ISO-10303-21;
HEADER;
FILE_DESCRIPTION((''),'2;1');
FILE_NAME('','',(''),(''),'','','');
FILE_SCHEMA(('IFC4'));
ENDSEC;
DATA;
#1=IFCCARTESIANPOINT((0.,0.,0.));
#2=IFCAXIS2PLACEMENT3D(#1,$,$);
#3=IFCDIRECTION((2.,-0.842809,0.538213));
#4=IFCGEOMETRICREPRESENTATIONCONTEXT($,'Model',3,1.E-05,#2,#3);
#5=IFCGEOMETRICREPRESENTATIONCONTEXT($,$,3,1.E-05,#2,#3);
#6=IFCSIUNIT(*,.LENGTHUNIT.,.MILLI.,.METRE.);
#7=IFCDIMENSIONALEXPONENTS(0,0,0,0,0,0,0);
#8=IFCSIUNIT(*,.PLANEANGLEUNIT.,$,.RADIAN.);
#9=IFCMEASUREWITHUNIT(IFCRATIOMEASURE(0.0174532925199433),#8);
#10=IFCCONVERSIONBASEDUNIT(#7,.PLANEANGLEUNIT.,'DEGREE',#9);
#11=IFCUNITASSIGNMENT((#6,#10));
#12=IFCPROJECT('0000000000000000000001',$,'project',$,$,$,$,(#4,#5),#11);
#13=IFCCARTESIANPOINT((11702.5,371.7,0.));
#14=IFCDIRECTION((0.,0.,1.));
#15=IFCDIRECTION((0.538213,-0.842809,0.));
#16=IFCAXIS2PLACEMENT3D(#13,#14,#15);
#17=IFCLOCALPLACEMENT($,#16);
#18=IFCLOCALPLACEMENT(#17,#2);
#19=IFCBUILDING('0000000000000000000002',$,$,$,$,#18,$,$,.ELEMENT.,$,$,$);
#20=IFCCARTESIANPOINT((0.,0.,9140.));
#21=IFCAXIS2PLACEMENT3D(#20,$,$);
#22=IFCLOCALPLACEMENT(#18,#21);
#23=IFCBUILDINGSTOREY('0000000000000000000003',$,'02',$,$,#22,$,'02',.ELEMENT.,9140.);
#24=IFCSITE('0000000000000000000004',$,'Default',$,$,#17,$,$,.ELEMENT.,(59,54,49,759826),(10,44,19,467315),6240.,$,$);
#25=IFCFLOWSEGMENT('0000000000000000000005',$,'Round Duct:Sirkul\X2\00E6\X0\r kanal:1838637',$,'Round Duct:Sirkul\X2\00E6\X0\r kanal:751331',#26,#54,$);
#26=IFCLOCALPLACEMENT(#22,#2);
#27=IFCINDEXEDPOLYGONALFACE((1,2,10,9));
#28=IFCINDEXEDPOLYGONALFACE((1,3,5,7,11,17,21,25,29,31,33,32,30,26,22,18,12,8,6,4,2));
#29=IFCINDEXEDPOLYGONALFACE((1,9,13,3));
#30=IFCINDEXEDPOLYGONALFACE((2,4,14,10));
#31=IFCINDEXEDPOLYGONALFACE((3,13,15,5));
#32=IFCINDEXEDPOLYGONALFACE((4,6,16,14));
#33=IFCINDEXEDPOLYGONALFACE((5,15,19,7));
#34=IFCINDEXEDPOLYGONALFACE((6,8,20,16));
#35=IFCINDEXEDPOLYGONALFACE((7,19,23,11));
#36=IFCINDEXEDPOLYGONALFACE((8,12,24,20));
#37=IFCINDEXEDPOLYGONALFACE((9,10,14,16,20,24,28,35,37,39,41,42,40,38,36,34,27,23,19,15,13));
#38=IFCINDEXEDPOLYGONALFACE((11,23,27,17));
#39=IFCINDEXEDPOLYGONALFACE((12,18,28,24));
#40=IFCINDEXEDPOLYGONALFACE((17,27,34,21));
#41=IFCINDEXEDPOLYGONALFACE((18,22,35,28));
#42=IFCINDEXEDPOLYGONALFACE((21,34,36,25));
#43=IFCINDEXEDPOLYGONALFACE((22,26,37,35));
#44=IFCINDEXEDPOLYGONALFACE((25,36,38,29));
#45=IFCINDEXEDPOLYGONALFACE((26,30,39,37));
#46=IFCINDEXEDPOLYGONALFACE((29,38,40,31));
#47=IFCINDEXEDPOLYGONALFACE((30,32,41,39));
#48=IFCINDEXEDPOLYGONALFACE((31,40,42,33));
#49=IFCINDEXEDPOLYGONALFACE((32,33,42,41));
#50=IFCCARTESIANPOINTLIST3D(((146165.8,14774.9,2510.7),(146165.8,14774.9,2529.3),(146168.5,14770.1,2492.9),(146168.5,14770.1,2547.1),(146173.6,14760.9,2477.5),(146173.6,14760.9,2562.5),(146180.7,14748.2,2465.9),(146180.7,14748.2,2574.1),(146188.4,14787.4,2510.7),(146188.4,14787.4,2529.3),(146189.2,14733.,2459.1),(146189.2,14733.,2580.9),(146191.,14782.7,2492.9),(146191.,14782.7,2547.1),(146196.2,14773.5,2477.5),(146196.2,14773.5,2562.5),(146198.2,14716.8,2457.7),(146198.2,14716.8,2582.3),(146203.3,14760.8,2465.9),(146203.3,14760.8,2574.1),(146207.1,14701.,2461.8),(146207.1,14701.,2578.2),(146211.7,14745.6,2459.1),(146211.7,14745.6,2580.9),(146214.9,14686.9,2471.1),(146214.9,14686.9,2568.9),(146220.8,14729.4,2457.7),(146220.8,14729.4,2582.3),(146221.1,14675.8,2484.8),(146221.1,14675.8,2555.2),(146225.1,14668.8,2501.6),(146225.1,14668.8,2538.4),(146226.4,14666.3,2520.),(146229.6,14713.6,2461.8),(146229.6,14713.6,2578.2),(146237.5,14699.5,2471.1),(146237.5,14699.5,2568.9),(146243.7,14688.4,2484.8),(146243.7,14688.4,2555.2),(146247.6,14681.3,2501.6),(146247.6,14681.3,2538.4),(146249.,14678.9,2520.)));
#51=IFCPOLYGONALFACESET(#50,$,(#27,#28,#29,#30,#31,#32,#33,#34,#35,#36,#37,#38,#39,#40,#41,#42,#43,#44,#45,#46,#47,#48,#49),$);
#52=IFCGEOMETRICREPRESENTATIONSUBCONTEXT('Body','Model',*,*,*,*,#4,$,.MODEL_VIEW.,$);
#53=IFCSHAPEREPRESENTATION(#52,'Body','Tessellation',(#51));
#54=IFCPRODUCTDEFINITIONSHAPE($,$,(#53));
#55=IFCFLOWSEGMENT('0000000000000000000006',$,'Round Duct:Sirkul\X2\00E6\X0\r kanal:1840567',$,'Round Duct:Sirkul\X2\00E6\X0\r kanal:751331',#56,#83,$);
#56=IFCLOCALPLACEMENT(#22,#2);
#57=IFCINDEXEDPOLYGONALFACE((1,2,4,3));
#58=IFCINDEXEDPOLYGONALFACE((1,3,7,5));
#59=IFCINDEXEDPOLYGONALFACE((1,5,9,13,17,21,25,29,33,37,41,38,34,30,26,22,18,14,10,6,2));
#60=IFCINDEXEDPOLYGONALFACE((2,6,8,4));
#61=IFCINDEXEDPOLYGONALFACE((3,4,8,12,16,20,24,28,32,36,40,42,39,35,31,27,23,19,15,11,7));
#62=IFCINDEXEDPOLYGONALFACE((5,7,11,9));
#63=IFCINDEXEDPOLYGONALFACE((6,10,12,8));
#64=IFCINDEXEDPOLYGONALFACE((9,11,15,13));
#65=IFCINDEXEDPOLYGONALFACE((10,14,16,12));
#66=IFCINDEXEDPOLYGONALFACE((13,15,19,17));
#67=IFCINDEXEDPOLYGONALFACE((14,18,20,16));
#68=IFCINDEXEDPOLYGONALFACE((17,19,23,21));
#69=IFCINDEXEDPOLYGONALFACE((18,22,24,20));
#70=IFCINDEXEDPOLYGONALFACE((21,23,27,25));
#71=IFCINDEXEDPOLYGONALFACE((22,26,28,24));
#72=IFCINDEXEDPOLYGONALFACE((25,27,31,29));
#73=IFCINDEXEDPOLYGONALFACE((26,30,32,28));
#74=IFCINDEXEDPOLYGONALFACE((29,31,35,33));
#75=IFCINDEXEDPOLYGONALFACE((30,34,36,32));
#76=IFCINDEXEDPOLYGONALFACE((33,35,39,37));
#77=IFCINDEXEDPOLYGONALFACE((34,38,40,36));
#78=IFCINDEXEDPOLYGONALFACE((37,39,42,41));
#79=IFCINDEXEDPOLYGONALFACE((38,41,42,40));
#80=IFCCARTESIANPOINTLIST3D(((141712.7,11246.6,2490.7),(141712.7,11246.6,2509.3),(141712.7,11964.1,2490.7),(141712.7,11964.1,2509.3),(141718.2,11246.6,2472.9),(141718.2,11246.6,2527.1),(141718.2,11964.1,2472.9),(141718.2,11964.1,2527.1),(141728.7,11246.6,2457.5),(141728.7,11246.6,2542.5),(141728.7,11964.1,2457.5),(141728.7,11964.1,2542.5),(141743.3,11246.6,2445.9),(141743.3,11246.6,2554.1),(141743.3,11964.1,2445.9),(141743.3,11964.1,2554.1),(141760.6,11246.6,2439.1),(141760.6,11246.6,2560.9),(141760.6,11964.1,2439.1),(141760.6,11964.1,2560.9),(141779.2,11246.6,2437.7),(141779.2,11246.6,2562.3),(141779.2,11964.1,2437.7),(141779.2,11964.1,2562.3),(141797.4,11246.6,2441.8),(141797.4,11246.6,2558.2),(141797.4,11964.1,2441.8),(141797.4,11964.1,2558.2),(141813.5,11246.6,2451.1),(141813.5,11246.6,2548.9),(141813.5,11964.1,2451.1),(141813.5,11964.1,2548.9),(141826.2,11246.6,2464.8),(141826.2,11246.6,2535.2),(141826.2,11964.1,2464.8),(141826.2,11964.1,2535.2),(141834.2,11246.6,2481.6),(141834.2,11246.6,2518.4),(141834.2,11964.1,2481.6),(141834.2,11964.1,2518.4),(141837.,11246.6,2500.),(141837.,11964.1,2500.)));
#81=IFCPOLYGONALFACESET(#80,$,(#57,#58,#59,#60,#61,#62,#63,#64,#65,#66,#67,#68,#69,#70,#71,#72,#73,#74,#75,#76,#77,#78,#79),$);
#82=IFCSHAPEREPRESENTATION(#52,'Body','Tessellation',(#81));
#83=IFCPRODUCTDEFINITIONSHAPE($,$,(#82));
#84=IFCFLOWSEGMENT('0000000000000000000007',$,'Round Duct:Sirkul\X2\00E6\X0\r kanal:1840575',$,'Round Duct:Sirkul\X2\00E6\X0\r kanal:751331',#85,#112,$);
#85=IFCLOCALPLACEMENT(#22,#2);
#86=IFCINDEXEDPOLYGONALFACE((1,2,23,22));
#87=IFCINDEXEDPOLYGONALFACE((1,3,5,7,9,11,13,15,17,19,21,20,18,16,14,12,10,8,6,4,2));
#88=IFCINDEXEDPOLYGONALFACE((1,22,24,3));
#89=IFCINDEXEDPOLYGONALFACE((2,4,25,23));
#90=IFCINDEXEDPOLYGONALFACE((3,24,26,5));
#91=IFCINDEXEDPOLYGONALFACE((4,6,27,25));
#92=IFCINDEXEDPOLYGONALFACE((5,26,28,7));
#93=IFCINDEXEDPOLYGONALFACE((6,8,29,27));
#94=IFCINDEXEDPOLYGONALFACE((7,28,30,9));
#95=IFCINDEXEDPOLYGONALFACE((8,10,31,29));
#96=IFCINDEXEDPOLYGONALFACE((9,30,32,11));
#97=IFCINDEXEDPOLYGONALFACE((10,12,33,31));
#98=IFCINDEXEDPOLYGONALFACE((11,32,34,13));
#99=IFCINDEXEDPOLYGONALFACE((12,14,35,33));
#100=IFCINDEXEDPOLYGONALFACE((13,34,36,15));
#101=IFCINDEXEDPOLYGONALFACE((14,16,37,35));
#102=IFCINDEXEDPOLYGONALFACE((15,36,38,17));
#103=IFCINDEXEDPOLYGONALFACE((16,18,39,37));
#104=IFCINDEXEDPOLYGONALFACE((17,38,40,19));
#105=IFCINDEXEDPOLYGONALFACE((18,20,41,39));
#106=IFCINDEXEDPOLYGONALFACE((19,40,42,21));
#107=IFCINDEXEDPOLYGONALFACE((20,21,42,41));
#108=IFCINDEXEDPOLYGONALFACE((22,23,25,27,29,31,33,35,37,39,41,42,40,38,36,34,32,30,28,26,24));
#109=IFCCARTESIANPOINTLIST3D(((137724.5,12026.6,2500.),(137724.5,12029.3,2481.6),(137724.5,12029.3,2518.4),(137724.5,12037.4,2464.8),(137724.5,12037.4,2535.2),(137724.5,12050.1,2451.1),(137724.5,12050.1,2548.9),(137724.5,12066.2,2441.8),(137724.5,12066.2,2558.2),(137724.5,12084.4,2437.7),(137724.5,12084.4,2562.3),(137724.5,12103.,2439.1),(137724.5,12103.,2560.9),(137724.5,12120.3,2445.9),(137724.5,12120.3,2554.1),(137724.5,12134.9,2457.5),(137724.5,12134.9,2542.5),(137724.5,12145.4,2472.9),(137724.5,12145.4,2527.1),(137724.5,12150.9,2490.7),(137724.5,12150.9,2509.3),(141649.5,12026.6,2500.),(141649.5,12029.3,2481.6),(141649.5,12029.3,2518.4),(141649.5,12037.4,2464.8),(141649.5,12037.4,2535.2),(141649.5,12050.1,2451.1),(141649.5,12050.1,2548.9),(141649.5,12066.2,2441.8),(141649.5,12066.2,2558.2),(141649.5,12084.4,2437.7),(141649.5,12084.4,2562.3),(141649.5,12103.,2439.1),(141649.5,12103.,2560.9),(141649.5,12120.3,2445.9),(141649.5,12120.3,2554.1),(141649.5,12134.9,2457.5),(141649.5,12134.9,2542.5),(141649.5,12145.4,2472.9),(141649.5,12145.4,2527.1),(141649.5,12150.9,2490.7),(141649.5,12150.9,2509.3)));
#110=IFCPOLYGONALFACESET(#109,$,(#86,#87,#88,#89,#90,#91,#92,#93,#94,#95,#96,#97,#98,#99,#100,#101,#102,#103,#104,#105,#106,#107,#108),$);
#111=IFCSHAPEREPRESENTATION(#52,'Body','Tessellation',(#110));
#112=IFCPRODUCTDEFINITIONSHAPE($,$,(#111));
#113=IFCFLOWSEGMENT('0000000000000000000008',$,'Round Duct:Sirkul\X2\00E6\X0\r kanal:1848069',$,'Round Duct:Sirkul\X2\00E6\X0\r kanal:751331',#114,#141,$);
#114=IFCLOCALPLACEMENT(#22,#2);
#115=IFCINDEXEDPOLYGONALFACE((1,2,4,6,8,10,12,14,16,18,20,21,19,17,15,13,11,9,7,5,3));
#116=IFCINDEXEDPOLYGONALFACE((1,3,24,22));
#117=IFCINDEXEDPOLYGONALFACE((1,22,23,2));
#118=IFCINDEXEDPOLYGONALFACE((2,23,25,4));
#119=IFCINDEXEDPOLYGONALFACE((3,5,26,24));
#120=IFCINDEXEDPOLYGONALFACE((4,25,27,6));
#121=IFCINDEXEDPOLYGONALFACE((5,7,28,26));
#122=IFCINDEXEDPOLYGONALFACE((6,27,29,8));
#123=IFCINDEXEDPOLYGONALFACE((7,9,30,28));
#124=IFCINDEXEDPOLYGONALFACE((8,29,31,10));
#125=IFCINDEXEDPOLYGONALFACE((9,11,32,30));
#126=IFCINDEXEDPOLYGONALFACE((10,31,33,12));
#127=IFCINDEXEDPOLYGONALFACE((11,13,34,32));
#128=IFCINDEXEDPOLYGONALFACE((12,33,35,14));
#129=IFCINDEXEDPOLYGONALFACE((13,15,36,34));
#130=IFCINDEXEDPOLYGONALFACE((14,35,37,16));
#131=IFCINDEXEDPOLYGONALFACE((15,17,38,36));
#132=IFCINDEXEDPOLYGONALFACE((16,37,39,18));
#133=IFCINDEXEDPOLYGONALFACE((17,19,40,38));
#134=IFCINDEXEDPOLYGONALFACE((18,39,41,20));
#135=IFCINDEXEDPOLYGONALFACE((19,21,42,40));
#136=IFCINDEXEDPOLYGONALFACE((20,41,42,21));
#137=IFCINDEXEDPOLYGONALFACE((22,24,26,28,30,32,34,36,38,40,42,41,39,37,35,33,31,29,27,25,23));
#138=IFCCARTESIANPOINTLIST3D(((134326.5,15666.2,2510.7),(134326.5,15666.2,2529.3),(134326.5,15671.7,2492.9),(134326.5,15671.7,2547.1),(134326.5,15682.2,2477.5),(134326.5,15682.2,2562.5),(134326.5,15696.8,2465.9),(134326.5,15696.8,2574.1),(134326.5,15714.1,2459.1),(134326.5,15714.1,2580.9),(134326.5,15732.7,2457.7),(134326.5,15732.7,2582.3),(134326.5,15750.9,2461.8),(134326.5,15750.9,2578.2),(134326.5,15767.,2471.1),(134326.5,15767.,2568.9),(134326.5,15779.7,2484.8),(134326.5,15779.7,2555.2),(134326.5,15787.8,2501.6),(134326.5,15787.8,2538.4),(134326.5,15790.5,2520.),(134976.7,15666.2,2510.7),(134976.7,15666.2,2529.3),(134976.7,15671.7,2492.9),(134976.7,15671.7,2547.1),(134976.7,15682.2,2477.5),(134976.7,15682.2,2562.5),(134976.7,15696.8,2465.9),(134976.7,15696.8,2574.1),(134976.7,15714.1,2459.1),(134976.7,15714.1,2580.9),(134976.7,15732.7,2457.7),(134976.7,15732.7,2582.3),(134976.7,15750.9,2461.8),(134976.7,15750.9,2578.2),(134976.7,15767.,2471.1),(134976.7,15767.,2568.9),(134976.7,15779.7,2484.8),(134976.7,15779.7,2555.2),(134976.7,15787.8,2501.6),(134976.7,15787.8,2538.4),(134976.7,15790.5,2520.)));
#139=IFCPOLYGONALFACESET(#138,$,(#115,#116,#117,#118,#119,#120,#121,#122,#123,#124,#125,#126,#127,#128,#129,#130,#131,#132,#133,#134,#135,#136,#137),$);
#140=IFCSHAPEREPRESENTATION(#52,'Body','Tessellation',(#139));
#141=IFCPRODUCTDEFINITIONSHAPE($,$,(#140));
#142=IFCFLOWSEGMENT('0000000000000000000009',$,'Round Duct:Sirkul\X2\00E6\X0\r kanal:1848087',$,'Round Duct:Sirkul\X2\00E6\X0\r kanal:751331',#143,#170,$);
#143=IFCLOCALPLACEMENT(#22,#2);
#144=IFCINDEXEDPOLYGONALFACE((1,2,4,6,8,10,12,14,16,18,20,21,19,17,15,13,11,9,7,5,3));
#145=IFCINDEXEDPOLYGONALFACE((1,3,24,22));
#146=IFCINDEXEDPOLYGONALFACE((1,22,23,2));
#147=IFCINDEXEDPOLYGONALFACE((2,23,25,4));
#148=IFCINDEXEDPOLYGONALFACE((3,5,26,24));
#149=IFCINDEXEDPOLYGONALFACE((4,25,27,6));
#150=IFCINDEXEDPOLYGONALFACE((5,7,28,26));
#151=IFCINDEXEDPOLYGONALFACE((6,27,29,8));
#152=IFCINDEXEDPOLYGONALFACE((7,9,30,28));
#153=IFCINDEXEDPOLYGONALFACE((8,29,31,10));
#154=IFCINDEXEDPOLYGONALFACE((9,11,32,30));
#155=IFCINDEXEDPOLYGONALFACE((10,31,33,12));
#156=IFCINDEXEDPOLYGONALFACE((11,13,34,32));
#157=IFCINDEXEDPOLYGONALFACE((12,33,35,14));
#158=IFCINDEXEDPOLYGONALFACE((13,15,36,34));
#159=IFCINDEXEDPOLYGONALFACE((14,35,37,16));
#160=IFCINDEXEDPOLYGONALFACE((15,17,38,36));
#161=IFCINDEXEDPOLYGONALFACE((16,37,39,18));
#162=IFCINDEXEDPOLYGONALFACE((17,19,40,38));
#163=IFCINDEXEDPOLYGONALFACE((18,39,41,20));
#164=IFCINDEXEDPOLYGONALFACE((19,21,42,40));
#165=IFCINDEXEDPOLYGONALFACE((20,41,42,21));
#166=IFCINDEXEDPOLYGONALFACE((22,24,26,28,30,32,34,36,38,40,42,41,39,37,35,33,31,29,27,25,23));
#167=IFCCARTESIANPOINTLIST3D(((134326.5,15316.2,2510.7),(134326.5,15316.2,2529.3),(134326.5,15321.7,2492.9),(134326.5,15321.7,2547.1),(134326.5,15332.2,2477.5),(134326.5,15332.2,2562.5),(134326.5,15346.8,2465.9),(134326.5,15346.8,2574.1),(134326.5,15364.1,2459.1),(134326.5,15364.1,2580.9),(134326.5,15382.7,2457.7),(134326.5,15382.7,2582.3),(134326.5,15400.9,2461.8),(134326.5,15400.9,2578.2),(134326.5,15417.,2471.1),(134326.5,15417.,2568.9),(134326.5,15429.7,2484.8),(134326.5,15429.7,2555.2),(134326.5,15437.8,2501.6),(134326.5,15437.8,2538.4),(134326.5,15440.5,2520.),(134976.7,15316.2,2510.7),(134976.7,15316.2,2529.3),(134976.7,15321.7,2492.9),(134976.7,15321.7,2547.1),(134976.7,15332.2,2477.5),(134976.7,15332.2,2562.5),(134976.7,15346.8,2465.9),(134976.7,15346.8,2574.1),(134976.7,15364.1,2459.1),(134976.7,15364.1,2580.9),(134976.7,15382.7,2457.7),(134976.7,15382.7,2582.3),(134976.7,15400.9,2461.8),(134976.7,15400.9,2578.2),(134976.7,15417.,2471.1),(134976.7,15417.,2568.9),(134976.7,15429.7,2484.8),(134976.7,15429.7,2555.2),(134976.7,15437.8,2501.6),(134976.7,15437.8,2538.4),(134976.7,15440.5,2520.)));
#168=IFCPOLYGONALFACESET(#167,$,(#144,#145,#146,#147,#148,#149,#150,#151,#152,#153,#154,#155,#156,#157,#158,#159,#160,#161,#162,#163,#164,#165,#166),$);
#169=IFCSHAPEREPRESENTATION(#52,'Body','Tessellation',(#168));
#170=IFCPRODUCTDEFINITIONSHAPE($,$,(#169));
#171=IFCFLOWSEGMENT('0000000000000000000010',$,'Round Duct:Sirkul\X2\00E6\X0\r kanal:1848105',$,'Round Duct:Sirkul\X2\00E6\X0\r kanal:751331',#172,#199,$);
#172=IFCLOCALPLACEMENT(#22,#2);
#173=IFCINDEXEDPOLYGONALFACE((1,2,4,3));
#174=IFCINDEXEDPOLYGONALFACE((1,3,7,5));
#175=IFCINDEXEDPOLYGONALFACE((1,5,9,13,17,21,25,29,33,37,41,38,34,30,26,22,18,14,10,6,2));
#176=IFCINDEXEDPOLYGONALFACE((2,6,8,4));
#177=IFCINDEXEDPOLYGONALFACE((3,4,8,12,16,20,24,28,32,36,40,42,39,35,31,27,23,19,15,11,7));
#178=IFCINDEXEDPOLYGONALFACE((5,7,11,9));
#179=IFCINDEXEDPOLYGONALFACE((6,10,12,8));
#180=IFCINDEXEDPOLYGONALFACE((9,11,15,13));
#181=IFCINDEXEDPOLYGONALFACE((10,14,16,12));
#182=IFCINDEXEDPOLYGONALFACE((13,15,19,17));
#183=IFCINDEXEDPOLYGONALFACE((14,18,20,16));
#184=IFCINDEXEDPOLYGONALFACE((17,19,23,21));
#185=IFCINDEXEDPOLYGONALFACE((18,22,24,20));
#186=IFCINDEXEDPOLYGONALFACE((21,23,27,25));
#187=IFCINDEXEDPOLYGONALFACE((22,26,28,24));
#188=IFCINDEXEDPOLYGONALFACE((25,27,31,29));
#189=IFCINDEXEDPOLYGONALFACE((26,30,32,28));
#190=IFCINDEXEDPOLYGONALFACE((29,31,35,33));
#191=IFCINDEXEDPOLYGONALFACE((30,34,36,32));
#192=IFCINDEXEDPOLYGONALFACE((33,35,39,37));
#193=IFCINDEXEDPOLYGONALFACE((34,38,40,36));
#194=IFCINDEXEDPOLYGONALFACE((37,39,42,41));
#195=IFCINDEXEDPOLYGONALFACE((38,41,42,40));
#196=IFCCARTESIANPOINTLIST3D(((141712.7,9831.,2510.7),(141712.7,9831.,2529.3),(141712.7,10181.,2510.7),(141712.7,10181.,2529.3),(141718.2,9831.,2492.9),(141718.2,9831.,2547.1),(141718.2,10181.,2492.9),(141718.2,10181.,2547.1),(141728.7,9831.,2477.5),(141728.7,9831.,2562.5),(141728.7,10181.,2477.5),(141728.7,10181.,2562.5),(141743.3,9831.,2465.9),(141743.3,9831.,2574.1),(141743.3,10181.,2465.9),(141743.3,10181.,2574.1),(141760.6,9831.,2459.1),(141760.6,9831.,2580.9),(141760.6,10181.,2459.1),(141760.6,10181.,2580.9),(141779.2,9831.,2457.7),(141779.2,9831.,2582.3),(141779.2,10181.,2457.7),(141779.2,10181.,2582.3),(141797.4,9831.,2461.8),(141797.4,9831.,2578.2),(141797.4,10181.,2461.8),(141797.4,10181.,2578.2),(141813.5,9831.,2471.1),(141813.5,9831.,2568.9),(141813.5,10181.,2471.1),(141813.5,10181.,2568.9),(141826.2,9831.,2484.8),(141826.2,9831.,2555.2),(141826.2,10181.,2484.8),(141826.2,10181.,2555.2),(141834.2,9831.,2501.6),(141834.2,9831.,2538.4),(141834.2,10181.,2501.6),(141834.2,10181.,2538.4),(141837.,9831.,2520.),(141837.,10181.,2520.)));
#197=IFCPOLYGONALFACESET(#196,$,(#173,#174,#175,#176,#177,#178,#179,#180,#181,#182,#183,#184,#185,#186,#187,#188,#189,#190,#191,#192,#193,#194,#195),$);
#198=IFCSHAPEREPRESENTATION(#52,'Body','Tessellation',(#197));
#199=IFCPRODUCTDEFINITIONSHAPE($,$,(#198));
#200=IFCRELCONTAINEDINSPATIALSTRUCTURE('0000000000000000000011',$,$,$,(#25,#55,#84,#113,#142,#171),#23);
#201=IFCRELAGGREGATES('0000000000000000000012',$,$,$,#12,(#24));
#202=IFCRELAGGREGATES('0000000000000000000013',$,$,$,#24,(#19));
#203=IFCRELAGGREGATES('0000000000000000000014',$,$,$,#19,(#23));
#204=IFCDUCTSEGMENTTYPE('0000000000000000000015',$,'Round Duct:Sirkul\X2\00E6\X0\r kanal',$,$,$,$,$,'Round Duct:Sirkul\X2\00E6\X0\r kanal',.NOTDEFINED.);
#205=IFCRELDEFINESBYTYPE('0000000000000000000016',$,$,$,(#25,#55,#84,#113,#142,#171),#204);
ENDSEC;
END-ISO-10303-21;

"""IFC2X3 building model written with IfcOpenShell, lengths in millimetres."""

from ifc_helpers import new_model, entity, si_unit, converted_unit, direction, frame, frame_2d, origin, origin_2d_with_axis, place, context, subcontext, project, spatial, circle, extrude, type_object, element, save


model = new_model("IFC2X3")

# Units and contexts
model_context = context("Model", 3, precision=1e-05, world=origin(), true_north=direction((2.0, -0.842809, 0.538213)))
context_of_model = context(None, 3, precision=1e-05, world=origin(), true_north=direction((2.0, -0.842809, 0.538213)))
body_context = subcontext(model_context, "Body", "Model", "MODEL_VIEW")
ifc_project = project(units=[si_unit("LENGTHUNIT", "METRE", prefix="MILLI"), converted_unit("PLANEANGLEUNIT", "DEGREE", entity("IfcRatioMeasure", 0.0174532925199433), si_unit("PLANEANGLEUNIT", "RADIAN"), dimensions=[0, 0, 0, 0, 0, 0, 0])], contexts=[model_context, context_of_model])

# Site, building, storey
site_placement = place(None, frame((11702.5, 371.7, 0.0), z_axis=(0.0, 0.0, 1.0), x_axis=(0.538213, -0.842809, 0.0)))
site = spatial("IfcSite", under=ifc_project, at=site_placement, Name="Default", CompositionType="ELEMENT", RefLatitude=(59, 54, 49, 759826), RefLongitude=(10, 44, 19, 467315), RefElevation=6240.0)
building_placement = place(site_placement, origin())
building = spatial("IfcBuilding", under=site, at=building_placement, CompositionType="ELEMENT")
storey_placement = place(building_placement, frame((0.0, 0.0, 9140.0)))
storey = spatial("IfcBuildingStorey", under=building, at=storey_placement, Name="02", LongName="02", CompositionType="ELEMENT", Elevation=9140.0)

# Flow segments
duct_segment_type_1 = type_object("IfcDuctSegmentType", Name="Round Duct:Sirkulær kanal", ElementType="Round Duct:Sirkulær kanal", PredefinedType="NOTDEFINED")
flow_segment_1_placement = place(storey_placement, origin())
element("IfcFlowSegment", 1, at=flow_segment_1_placement, inside=storey, type_object=duct_segment_type_1, Name="Round Duct:Sirkulær kanal:1838637", ObjectType="Round Duct:Sirkulær kanal:751331", context=body_context, shape_type="SweptSolid", body=[
    extrude(circle(Radius=62.5, at=frame_2d((0.0, 0.0), x_axis=(1.0, 0.0))), frame((146195.9, 14720.9, 2520.0), z_axis=(0.873101, 0.487539, 0.0), x_axis=(0.487539, -0.873101, 0.0)), (0.0, 0.0, 1.0), 25.8),
])
flow_segment_2_placement = place(storey_placement, origin())
element("IfcFlowSegment", 2, at=flow_segment_2_placement, inside=storey, type_object=duct_segment_type_1, Name="Round Duct:Sirkulær kanal:1840567", ObjectType="Round Duct:Sirkulær kanal:751331", context=body_context, shape_type="SweptSolid", body=[
    extrude(circle(Radius=62.5, at=frame_2d((0.0, 0.0), x_axis=(1.0, 0.0))), frame((141774.5, 11246.6, 2500.0), z_axis=(0.0, 1.0, 0.0), x_axis=(1.0, 0.0, 0.0)), (0.0, 0.0, 1.0), 717.5),
])
flow_segment_3_placement = place(storey_placement, origin())
element("IfcFlowSegment", 3, at=flow_segment_3_placement, inside=storey, type_object=duct_segment_type_1, Name="Round Duct:Sirkulær kanal:1840575", ObjectType="Round Duct:Sirkulær kanal:751331", context=body_context, shape_type="SweptSolid", body=[
    extrude(circle(Radius=62.5, at=frame_2d((0.0, 0.0), x_axis=(1.0, 0.0))), frame((137724.5, 12089.1, 2500.0), z_axis=(1.0, 0.0, 0.0), x_axis=(0.0, -1.0, 0.0)), (0.0, 0.0, 1.0), 3925.0),
])
flow_segment_4_placement = place(storey_placement, origin())
element("IfcFlowSegment", 4, at=flow_segment_4_placement, inside=storey, type_object=duct_segment_type_1, Name="Round Duct:Sirkulær kanal:1848069", ObjectType="Round Duct:Sirkulær kanal:751331", context=body_context, shape_type="SweptSolid", body=[
    extrude(circle(Radius=62.5, at=frame_2d((0.0, 0.0), x_axis=(1.0, 0.0))), frame((134326.5, 15728.0, 2520.0), z_axis=(1.0, 0.0, 0.0), x_axis=(0.0, 1.0, 0.0)), (0.0, 0.0, 1.0), 650.3),
])
flow_segment_5_placement = place(storey_placement, origin())
element("IfcFlowSegment", 5, at=flow_segment_5_placement, inside=storey, type_object=duct_segment_type_1, Name="Round Duct:Sirkulær kanal:1848087", ObjectType="Round Duct:Sirkulær kanal:751331", context=body_context, shape_type="SweptSolid", body=[
    extrude(circle(Radius=62.5, at=frame_2d((0.0, 0.0), x_axis=(1.0, 0.0))), frame((134326.5, 15378.0, 2520.0), z_axis=(1.0, 0.0, 0.0), x_axis=(0.0, 1.0, 0.0)), (0.0, 0.0, 1.0), 650.3),
])
flow_segment_6_placement = place(storey_placement, origin())
element("IfcFlowSegment", 6, at=flow_segment_6_placement, inside=storey, type_object=duct_segment_type_1, Name="Round Duct:Sirkulær kanal:1848105", ObjectType="Round Duct:Sirkulær kanal:751331", context=body_context, shape_type="SweptSolid", body=[
    extrude(circle(Radius=62.5, at=origin_2d_with_axis()), frame((141774.5, 9831.0, 2520.0), z_axis=(0.0, 1.0, 0.0), x_axis=(1.0, 0.0, 0.0)), (0.0, 0.0, 1.0), 350.0),
])

save(model, "model.ifc")
